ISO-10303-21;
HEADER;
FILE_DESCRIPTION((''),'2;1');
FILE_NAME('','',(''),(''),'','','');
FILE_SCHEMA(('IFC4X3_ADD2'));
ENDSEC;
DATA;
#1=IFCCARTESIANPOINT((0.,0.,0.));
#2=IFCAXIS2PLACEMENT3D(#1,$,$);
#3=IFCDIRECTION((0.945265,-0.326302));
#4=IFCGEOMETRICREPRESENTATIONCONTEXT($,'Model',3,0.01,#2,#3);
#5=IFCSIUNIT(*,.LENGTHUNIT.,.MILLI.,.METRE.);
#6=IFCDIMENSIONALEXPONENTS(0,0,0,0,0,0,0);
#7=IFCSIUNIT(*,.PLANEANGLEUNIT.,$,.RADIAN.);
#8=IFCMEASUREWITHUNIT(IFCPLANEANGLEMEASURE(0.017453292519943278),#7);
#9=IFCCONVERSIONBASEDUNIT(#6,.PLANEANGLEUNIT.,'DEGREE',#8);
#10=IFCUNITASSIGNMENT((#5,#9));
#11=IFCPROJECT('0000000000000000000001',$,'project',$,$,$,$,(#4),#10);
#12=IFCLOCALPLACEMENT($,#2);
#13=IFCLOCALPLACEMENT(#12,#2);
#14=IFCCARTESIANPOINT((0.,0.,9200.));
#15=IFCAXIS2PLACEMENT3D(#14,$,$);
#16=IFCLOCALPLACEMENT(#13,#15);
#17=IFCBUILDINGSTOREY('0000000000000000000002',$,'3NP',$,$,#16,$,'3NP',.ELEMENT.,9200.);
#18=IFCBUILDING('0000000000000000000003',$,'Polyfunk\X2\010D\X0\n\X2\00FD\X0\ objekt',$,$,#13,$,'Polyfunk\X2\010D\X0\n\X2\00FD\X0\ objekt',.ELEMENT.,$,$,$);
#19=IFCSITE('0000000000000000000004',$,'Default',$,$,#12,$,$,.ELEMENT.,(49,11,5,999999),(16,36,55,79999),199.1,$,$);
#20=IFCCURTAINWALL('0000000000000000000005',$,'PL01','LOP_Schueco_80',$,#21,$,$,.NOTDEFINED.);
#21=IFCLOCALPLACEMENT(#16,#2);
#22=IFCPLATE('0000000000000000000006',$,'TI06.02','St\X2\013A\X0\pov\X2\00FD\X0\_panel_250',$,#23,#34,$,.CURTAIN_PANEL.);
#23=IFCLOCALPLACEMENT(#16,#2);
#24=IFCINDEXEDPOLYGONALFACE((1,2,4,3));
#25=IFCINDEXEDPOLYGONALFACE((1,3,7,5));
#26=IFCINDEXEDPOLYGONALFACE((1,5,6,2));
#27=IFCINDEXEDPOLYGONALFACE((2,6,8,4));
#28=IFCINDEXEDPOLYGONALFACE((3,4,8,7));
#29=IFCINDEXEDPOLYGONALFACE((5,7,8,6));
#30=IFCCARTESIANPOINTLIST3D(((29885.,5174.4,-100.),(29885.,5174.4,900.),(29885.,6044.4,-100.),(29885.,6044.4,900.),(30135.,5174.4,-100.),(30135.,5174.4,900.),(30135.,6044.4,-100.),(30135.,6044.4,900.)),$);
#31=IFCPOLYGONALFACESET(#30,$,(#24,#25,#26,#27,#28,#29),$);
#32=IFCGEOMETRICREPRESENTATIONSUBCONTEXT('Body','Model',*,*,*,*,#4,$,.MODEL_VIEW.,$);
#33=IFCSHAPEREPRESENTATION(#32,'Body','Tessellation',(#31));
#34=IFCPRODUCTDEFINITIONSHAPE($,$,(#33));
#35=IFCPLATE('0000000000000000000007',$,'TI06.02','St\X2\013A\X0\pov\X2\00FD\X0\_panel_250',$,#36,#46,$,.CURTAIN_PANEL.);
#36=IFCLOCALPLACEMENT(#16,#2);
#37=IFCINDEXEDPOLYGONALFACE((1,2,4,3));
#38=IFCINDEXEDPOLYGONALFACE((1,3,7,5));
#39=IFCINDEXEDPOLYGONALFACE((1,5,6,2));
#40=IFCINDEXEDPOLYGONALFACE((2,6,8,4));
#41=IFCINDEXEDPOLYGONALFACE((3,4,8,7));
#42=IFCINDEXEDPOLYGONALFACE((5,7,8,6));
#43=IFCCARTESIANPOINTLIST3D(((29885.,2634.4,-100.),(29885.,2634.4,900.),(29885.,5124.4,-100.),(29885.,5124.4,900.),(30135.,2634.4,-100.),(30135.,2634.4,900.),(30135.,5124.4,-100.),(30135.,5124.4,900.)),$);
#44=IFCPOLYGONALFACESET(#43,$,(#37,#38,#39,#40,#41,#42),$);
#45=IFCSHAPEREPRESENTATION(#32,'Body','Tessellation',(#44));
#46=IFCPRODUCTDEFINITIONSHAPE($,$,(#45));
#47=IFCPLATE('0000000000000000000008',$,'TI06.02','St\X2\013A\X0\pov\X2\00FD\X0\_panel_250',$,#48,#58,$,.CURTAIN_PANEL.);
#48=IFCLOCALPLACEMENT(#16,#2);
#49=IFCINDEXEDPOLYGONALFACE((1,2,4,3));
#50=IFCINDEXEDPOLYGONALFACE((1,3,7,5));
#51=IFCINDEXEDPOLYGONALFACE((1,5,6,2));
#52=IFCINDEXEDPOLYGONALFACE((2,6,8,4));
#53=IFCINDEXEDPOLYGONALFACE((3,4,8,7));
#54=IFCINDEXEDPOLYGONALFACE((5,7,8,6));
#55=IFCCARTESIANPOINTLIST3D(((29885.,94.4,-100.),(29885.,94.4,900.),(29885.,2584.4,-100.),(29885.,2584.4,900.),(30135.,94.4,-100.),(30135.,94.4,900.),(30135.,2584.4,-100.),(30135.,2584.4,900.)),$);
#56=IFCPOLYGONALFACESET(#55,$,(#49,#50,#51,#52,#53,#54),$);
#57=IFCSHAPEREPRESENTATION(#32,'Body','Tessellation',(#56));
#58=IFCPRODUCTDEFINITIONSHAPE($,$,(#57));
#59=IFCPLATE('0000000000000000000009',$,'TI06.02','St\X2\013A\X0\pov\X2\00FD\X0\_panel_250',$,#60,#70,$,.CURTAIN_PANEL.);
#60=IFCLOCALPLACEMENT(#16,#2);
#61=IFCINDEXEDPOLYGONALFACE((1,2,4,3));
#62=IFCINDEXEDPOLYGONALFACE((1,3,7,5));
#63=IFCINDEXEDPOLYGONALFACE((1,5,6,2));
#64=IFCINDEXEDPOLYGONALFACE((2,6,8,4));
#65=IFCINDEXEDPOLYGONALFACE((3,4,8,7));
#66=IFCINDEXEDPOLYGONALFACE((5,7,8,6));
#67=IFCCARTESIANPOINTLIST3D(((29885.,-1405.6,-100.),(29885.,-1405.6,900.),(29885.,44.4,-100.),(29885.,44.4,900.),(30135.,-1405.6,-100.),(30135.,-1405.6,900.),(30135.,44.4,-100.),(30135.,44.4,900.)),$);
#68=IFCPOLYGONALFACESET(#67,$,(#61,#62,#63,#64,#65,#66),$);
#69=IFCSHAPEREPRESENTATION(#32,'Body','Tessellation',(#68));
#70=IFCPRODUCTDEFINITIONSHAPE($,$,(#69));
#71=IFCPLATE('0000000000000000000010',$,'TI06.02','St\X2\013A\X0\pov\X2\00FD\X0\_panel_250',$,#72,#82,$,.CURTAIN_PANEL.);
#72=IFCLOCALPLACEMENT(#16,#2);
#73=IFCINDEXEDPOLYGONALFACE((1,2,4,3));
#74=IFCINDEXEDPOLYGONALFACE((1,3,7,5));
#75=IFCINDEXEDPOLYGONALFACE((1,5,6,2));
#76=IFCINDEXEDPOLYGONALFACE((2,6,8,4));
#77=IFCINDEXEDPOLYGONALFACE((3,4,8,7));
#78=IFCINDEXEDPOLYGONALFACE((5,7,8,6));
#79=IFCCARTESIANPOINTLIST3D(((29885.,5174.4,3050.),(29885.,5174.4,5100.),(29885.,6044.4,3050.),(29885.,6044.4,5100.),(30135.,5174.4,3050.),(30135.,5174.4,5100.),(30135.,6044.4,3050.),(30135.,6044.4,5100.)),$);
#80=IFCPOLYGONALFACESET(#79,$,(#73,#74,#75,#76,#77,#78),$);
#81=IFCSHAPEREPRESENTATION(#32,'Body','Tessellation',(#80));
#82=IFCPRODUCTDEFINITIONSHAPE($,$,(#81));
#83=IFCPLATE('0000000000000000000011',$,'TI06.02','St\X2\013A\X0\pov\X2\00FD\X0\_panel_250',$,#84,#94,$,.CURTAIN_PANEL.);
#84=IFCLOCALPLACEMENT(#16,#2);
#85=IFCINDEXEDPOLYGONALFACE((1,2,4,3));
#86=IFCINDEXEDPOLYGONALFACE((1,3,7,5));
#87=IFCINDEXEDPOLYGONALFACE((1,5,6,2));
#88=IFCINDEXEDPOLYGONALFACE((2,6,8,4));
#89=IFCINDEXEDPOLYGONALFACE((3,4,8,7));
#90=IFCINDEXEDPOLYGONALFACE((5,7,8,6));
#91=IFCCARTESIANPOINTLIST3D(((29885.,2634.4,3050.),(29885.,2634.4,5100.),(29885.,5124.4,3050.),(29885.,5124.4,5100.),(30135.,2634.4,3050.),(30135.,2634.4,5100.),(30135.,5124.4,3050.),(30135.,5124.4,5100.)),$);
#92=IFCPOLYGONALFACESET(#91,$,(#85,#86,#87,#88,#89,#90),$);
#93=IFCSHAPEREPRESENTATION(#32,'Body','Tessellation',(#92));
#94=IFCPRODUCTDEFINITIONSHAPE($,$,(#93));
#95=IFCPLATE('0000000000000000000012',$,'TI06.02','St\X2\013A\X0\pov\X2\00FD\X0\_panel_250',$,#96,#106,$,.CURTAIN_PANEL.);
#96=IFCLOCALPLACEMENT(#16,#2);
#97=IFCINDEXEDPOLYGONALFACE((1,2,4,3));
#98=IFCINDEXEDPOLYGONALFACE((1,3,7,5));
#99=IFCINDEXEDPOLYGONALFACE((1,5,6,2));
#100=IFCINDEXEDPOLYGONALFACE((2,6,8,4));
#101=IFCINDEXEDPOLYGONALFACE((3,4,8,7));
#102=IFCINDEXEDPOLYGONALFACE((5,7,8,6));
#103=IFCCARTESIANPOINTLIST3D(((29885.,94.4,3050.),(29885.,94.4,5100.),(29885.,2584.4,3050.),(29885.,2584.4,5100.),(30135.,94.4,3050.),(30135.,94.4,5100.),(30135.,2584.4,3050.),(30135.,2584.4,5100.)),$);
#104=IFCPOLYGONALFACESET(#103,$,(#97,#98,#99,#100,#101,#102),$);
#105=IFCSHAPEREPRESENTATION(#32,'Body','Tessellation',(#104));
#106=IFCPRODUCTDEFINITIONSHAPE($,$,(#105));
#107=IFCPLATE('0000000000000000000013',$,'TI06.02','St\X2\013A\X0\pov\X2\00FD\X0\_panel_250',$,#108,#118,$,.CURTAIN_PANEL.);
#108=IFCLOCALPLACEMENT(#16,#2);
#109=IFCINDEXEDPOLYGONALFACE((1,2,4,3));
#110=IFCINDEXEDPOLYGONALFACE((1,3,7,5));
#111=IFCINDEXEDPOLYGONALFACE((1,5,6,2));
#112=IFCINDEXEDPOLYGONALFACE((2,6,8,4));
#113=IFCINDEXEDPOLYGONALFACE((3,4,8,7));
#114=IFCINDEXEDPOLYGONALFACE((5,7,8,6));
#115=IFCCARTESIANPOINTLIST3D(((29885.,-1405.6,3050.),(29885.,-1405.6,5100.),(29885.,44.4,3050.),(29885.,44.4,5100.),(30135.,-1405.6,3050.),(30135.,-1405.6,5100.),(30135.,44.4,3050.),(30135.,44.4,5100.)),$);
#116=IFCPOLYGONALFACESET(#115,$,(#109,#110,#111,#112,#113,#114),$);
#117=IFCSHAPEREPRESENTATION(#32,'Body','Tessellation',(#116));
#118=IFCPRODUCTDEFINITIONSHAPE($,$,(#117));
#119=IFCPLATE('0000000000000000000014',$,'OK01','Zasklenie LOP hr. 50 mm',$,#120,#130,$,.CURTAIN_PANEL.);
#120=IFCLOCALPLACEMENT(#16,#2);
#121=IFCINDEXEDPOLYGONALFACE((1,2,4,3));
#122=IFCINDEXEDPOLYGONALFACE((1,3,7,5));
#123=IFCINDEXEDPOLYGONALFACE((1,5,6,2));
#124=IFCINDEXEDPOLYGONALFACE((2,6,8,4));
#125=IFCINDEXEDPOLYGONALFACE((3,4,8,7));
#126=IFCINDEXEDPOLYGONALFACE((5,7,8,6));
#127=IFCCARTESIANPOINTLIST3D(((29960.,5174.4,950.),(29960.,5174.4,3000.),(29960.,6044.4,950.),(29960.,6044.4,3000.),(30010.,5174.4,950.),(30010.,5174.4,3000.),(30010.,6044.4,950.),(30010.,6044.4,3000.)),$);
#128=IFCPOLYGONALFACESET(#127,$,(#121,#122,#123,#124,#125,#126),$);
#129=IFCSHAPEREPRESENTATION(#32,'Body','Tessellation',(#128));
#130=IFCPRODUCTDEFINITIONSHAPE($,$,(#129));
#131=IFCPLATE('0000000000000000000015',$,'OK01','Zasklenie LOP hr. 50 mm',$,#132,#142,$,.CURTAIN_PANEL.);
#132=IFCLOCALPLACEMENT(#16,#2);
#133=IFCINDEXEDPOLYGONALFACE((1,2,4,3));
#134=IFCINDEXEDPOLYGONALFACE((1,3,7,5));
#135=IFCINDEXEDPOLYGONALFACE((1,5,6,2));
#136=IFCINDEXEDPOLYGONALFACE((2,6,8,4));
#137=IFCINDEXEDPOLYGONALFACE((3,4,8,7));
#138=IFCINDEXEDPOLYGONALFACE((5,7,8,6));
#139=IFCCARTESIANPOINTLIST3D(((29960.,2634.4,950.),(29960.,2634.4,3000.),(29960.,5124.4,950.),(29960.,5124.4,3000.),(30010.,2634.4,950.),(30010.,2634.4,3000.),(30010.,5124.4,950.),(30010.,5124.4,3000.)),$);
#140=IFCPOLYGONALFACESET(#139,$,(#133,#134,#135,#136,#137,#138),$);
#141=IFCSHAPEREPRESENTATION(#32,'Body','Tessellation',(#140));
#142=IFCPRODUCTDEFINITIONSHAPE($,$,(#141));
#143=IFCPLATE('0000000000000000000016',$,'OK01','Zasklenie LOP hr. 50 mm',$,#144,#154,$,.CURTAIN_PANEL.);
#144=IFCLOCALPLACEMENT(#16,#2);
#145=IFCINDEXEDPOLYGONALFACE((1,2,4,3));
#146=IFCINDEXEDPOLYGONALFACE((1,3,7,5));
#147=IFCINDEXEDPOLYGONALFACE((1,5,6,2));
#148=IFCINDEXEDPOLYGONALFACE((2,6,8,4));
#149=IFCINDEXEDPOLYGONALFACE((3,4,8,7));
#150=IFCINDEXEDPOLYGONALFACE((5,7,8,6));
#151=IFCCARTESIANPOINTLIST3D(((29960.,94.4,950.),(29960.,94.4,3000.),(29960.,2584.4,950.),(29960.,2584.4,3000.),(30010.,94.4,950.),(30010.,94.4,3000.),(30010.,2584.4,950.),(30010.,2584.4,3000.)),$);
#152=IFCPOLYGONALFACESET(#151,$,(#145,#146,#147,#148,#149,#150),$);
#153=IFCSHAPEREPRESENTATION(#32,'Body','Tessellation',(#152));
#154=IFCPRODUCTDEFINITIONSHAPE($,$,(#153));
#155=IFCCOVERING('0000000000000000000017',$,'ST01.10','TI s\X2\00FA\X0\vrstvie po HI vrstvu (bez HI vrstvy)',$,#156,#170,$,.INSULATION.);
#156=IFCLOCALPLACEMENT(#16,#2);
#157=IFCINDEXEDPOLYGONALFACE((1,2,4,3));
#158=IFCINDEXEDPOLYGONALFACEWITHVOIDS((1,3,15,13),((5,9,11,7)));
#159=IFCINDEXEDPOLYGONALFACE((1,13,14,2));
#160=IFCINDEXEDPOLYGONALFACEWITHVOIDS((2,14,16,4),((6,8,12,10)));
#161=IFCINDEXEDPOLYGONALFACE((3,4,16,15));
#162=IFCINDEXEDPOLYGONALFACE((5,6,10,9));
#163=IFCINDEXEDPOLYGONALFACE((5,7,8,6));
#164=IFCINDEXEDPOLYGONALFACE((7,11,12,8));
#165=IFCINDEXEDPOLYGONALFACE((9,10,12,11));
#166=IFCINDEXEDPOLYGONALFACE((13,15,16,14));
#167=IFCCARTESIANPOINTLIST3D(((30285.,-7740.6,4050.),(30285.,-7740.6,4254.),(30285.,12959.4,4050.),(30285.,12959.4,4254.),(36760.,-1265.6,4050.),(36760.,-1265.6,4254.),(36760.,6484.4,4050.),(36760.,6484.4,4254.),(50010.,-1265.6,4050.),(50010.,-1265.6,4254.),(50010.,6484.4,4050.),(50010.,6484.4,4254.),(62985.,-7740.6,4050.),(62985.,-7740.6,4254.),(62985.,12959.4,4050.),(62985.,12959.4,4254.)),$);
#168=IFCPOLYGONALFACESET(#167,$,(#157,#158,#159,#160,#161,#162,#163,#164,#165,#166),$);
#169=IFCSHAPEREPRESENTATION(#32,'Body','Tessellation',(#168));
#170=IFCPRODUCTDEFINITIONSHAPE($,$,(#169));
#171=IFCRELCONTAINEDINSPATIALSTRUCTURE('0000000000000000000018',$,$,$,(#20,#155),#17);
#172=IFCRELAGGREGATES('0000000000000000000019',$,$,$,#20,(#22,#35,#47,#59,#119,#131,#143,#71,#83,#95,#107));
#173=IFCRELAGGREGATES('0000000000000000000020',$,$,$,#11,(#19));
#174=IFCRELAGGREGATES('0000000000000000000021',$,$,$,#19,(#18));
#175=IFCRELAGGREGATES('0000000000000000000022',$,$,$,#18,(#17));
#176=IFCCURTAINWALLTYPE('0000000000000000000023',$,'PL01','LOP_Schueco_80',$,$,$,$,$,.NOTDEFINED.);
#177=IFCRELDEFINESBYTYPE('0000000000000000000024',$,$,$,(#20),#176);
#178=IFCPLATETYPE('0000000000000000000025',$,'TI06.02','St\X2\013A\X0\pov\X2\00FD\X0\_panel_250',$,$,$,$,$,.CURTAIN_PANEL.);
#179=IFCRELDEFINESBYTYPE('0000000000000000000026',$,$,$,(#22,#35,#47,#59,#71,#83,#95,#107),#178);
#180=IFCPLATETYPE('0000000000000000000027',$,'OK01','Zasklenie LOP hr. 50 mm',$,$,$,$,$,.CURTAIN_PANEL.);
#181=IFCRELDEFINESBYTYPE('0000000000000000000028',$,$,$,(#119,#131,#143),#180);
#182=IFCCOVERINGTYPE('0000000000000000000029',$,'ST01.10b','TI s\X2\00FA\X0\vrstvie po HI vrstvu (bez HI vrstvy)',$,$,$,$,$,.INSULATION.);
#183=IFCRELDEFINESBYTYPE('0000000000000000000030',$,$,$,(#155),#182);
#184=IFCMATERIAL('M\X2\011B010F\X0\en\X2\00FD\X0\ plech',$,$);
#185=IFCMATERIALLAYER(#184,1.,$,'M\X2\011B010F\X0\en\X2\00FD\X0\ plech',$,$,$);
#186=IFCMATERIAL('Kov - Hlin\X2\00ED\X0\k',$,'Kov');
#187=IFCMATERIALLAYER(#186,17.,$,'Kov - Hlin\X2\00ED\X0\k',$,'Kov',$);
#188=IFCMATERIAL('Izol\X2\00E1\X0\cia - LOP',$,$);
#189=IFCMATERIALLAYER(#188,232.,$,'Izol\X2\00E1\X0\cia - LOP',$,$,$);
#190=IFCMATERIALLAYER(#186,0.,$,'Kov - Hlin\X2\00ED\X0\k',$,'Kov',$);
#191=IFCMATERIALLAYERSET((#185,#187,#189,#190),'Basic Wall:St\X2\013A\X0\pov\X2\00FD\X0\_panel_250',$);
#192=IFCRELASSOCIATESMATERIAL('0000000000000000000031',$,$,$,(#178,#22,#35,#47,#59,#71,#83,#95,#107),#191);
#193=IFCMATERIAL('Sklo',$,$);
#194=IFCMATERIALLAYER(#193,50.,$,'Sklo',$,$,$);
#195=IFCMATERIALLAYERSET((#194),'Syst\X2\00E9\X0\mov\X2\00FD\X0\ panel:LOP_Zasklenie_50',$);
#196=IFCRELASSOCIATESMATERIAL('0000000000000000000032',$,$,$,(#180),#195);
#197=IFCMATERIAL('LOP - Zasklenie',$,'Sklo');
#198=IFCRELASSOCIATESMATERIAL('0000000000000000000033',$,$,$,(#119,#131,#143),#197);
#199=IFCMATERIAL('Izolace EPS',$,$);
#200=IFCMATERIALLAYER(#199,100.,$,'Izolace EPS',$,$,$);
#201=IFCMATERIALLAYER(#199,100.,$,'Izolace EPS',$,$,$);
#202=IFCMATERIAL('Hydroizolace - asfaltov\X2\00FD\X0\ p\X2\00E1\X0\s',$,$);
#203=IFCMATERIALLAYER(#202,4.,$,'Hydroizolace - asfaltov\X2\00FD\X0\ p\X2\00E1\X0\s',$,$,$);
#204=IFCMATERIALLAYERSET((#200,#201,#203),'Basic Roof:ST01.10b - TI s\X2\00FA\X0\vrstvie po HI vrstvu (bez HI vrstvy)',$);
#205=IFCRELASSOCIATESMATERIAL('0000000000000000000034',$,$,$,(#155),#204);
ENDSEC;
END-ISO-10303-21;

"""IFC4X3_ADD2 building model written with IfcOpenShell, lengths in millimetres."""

from ifc_helpers import new_model, entity, si_unit, converted_unit, direction, frame, frame_2d, origin, origin_2d_with_axis, place, context, subcontext, project, spatial, rectangle, extrude, source, transform, mapped, material, layer, layer_set, layer_usage, type_object, type_shapes, element, aggregate, save


model = new_model("IFC4X3_ADD2")

# Units and contexts
model_context = context("Model", 3, precision=0.01, world=origin(), true_north=direction((0.945265, -0.326302)))
body_context = subcontext(model_context, "Body", "Model", "MODEL_VIEW")
ifc_project = project(units=[si_unit("LENGTHUNIT", "METRE", prefix="MILLI"), converted_unit("PLANEANGLEUNIT", "DEGREE", entity("IfcPlaneAngleMeasure", 0.017453292519943278), si_unit("PLANEANGLEUNIT", "RADIAN"), dimensions=[0, 0, 0, 0, 0, 0, 0])], contexts=[model_context])

# Site, building, storey
site_placement = place(None, origin())
site = spatial("IfcSite", under=ifc_project, at=site_placement, Name="Default", CompositionType="ELEMENT", RefLatitude=(49, 11, 5, 999999), RefLongitude=(16, 36, 55, 79999), RefElevation=199.1)
building_placement = place(site_placement, origin())
building = spatial("IfcBuilding", under=site, at=building_placement, Name="Polyfunkčný objekt", LongName="Polyfunkčný objekt", CompositionType="ELEMENT")
storey_placement = place(building_placement, frame((0.0, 0.0, 9200.0)))
storey = spatial("IfcBuildingStorey", under=building, at=storey_placement, Name="3NP", LongName="3NP", CompositionType="ELEMENT", Elevation=9200.0)

# Curtain wall
curtain_wall_type = type_object("IfcCurtainWallType", Name="PL01", Description="LOP_Schueco_80", PredefinedType="NOTDEFINED")
curtain_wall_1_placement = place(storey_placement, frame((0.0, 0.0, -9200.0)))
curtain_wall_1 = element("IfcCurtainWall", 1, at=curtain_wall_1_placement, inside=storey, type_object=curtain_wall_type, Name="PL01", Description="LOP_Schueco_80", PredefinedType="NOTDEFINED")

# Plates
ifc_material_1 = material(Name="Měďený plech")
ifc_layer_1 = layer(ifc_material_1, 1.0, Name="Měďený plech")
ifc_material_2 = material(Name="Kov - Hliník", Category="Kov")
ifc_layer_2 = layer(ifc_material_2, 17.0, Name="Kov - Hliník", Category="Kov")
ifc_material_3 = material(Name="Izolácia - LOP")
ifc_layer_3 = layer(ifc_material_3, 232.0, Name="Izolácia - LOP")
ifc_layer_4 = layer(ifc_material_2, 0.0, Name="Kov - Hliník", Category="Kov")
ifc_layer_set_1 = layer_set([ifc_layer_1, ifc_layer_2, ifc_layer_3, ifc_layer_4], Name="Basic Wall:Stĺpový_panel_250")
ifc_layer_usage_1 = layer_usage(ifc_layer_set_1, "AXIS2", "POSITIVE", -125.0)
plate_type_1 = type_object("IfcPlateType", Name="TI06.02", Description="Stĺpový_panel_250", PredefinedType="CURTAIN_PANEL", material=ifc_layer_set_1)
plate_1_placement = place(storey_placement, frame((30010.0, 6044.4, -100.0), z_axis=(0.0, 0.0, 1.0), x_axis=(0.0, -1.0, 0.0)))
plate_1 = element("IfcPlate", 2, at=plate_1_placement, type_object=plate_type_1, material=ifc_layer_usage_1, Name="TI06.02", Description="Stĺpový_panel_250", PredefinedType="CURTAIN_PANEL", context=body_context, shape_type="SweptSolid", body=[
    extrude(rectangle(XDim=250.0, YDim=870.0, at=frame_2d((0.0, 0.0), x_axis=(1.0, 0.0))), frame((435.0, 0.0, 0.0), z_axis=(0.0, 0.0, 1.0), x_axis=(0.0, 1.0, 0.0)), (0.0, 0.0, 1.0), 1000.0),
])
ifc_layer_usage_2 = layer_usage(ifc_layer_set_1, "AXIS2", "POSITIVE", -125.0)
plate_2_placement = place(storey_placement, frame((30010.0, 5124.4, -100.0), z_axis=(0.0, 0.0, 1.0), x_axis=(0.0, -1.0, 0.0)))
plate_2 = element("IfcPlate", 3, at=plate_2_placement, type_object=plate_type_1, material=ifc_layer_usage_2, Name="TI06.02", Description="Stĺpový_panel_250", PredefinedType="CURTAIN_PANEL", context=body_context, shape_type="SweptSolid", body=[
    extrude(rectangle(XDim=250.0, YDim=2490.0, at=frame_2d((0.0, 0.0), x_axis=(1.0, 0.0))), frame((1245.0, 0.0, 0.0), z_axis=(0.0, 0.0, 1.0), x_axis=(0.0, 1.0, 0.0)), (0.0, 0.0, 1.0), 1000.0),
])
ifc_layer_usage_3 = layer_usage(ifc_layer_set_1, "AXIS2", "POSITIVE", -125.0)
plate_3_placement = place(storey_placement, frame((30010.0, 2584.4, -100.0), z_axis=(0.0, 0.0, 1.0), x_axis=(0.0, -1.0, 0.0)))
plate_3 = element("IfcPlate", 4, at=plate_3_placement, type_object=plate_type_1, material=ifc_layer_usage_3, Name="TI06.02", Description="Stĺpový_panel_250", PredefinedType="CURTAIN_PANEL", context=body_context, shape_type="SweptSolid", body=[
    extrude(rectangle(XDim=250.0, YDim=2490.0, at=frame_2d((0.0, 0.0), x_axis=(1.0, 0.0))), frame((1245.0, 0.0, 0.0), z_axis=(0.0, 0.0, 1.0), x_axis=(0.0, 1.0, 0.0)), (0.0, 0.0, 1.0), 1000.0),
])
ifc_layer_usage_4 = layer_usage(ifc_layer_set_1, "AXIS2", "POSITIVE", -125.0)
plate_4_placement = place(storey_placement, frame((30010.0, 44.4, -100.0), z_axis=(0.0, 0.0, 1.0), x_axis=(0.0, -1.0, 0.0)))
plate_4 = element("IfcPlate", 5, at=plate_4_placement, type_object=plate_type_1, material=ifc_layer_usage_4, Name="TI06.02", Description="Stĺpový_panel_250", PredefinedType="CURTAIN_PANEL", context=body_context, shape_type="SweptSolid", body=[
    extrude(rectangle(XDim=250.0, YDim=1450.0, at=frame_2d((0.0, 0.0), x_axis=(1.0, 0.0))), frame((725.0, 0.0, 0.0), z_axis=(0.0, 0.0, 1.0), x_axis=(0.0, 1.0, 0.0)), (0.0, 0.0, 1.0), 1000.0),
])
ifc_layer_usage_5 = layer_usage(ifc_layer_set_1, "AXIS2", "POSITIVE", -125.0)
plate_5_placement = place(storey_placement, frame((30010.0, 6044.4, 3050.0), z_axis=(0.0, 0.0, 1.0), x_axis=(0.0, -1.0, 0.0)))
plate_5 = element("IfcPlate", 6, at=plate_5_placement, type_object=plate_type_1, material=ifc_layer_usage_5, Name="TI06.02", Description="Stĺpový_panel_250", PredefinedType="CURTAIN_PANEL", context=body_context, shape_type="SweptSolid", body=[
    extrude(rectangle(XDim=250.0, YDim=870.0, at=frame_2d((0.0, 0.0), x_axis=(1.0, 0.0))), frame((435.0, 0.0, 0.0), z_axis=(0.0, 0.0, 1.0), x_axis=(0.0, 1.0, 0.0)), (0.0, 0.0, 1.0), 2050.0),
])
ifc_layer_usage_6 = layer_usage(ifc_layer_set_1, "AXIS2", "POSITIVE", -125.0)
plate_6_placement = place(storey_placement, frame((30010.0, 5124.4, 3050.0), z_axis=(0.0, 0.0, 1.0), x_axis=(0.0, -1.0, 0.0)))
plate_6 = element("IfcPlate", 7, at=plate_6_placement, type_object=plate_type_1, material=ifc_layer_usage_6, Name="TI06.02", Description="Stĺpový_panel_250", PredefinedType="CURTAIN_PANEL", context=body_context, shape_type="SweptSolid", body=[
    extrude(rectangle(XDim=250.0, YDim=2490.0, at=frame_2d((0.0, 0.0), x_axis=(1.0, 0.0))), frame((1245.0, 0.0, 0.0), z_axis=(0.0, 0.0, 1.0), x_axis=(0.0, 1.0, 0.0)), (0.0, 0.0, 1.0), 2050.0),
])
ifc_layer_usage_7 = layer_usage(ifc_layer_set_1, "AXIS2", "POSITIVE", -125.0)
plate_7_placement = place(storey_placement, frame((30010.0, 2584.4, 3050.0), z_axis=(0.0, 0.0, 1.0), x_axis=(0.0, -1.0, 0.0)))
plate_7 = element("IfcPlate", 8, at=plate_7_placement, type_object=plate_type_1, material=ifc_layer_usage_7, Name="TI06.02", Description="Stĺpový_panel_250", PredefinedType="CURTAIN_PANEL", context=body_context, shape_type="SweptSolid", body=[
    extrude(rectangle(XDim=250.0, YDim=2490.0, at=frame_2d((0.0, 0.0), x_axis=(1.0, 0.0))), frame((1245.0, 0.0, 0.0), z_axis=(0.0, 0.0, 1.0), x_axis=(0.0, 1.0, 0.0)), (0.0, 0.0, 1.0), 2050.0),
])
ifc_layer_usage_8 = layer_usage(ifc_layer_set_1, "AXIS2", "POSITIVE", -125.0)
plate_8_placement = place(storey_placement, frame((30010.0, 44.4, 3050.0), z_axis=(0.0, 0.0, 1.0), x_axis=(0.0, -1.0, 0.0)))
plate_8 = element("IfcPlate", 9, at=plate_8_placement, type_object=plate_type_1, material=ifc_layer_usage_8, Name="TI06.02", Description="Stĺpový_panel_250", PredefinedType="CURTAIN_PANEL", context=body_context, shape_type="SweptSolid", body=[
    extrude(rectangle(XDim=250.0, YDim=1450.0, at=frame_2d((0.0, 0.0), x_axis=(1.0, 0.0))), frame((725.0, 0.0, 0.0), z_axis=(0.0, 0.0, 1.0), x_axis=(0.0, 1.0, 0.0)), (0.0, 0.0, 1.0), 2050.0),
])
ifc_material_4 = material(Name="LOP - Zasklenie", Category="Sklo")
ifc_material_5 = material(Name="Sklo")
ifc_layer_5 = layer(ifc_material_5, 50.0, Name="Sklo")
ifc_layer_set_2 = layer_set([ifc_layer_5], Name="Systémový panel:LOP_Zasklenie_50")
plate_type_2 = type_object("IfcPlateType", Name="OK01", Description="Zasklenie LOP hr. 50 mm", PredefinedType="CURTAIN_PANEL", material=ifc_layer_set_2)
shared_shape_1 = source(origin(), body_context, "Body", "SweptSolid", [
    extrude(rectangle(XDim=50.0, YDim=870.0, at=origin_2d_with_axis()), frame((0.0, -25.0, 0.0), z_axis=(0.0, 0.0, 1.0), x_axis=(0.0, 1.0, 0.0)), (0.0, 0.0, 1.0), 2050.0),
])
plate_9_placement = place(curtain_wall_1_placement, frame((30010.0, 5609.4, 10150.0), z_axis=(0.0, 0.0, 1.0), x_axis=(0.0, -1.0, 0.0)))
plate_9 = element("IfcPlate", 10, at=plate_9_placement, type_object=plate_type_2, material=ifc_material_4, Name="OK01", Description="Zasklenie LOP hr. 50 mm", PredefinedType="CURTAIN_PANEL", context=body_context, shape_type="MappedRepresentation", body=[
    mapped(shared_shape_1, transform((0.0, 0.0, 0.0), scale=1.0)),
])
shared_shape_2 = source(origin(), body_context, "Body", "SweptSolid", [
    extrude(rectangle(XDim=50.0, YDim=2490.0, at=origin_2d_with_axis()), frame((0.0, -25.0, 0.0), z_axis=(0.0, 0.0, 1.0), x_axis=(0.0, 1.0, 0.0)), (0.0, 0.0, 1.0), 2050.0),
])
type_shapes(plate_type_2, [shared_shape_1, shared_shape_2])
plate_10_placement = place(curtain_wall_1_placement, frame((30010.0, 3879.4, 10150.0), z_axis=(0.0, 0.0, 1.0), x_axis=(0.0, -1.0, 0.0)))
plate_10 = element("IfcPlate", 11, at=plate_10_placement, type_object=plate_type_2, material=ifc_material_4, Name="OK01", Description="Zasklenie LOP hr. 50 mm", PredefinedType="CURTAIN_PANEL", context=body_context, shape_type="MappedRepresentation", body=[
    mapped(shared_shape_2, transform((0.0, 0.0, 0.0), scale=1.0)),
])
plate_11_placement = place(curtain_wall_1_placement, frame((30010.0, 1339.4, 10150.0), z_axis=(0.0, 0.0, 1.0), x_axis=(0.0, -1.0, 0.0)))
plate_11 = element("IfcPlate", 12, at=plate_11_placement, type_object=plate_type_2, material=ifc_material_4, Name="OK01", Description="Zasklenie LOP hr. 50 mm", PredefinedType="CURTAIN_PANEL", context=body_context, shape_type="MappedRepresentation", body=[
    mapped(shared_shape_2, transform((0.0, 0.0, 0.0), scale=1.0)),
])
aggregate(curtain_wall_1, [plate_1, plate_2, plate_3, plate_4, plate_9, plate_10, plate_11, plate_5, plate_6, plate_7, plate_8])

# Covering, opening
ifc_material_6 = material(Name="Izolace EPS")
ifc_layer_6 = layer(ifc_material_6, 100.0, Name="Izolace EPS")
ifc_layer_7 = layer(ifc_material_6, 100.0, Name="Izolace EPS")
ifc_material_7 = material(Name="Hydroizolace - asfaltový pás")
ifc_layer_8 = layer(ifc_material_7, 4.0, Name="Hydroizolace - asfaltový pás")
ifc_layer_set_3 = layer_set([ifc_layer_6, ifc_layer_7, ifc_layer_8], Name="Basic Roof:ST01.10b - TI súvrstvie po HI vrstvu (bez HI vrstvy)")
covering_type_1 = type_object("IfcCoveringType", Name="ST01.10b", Description="TI súvrstvie po HI vrstvu (bez HI vrstvy)", PredefinedType="INSULATION")
covering_1_placement = place(storey_placement, frame((30285.0, -7740.6, 4050.0)))
covering_1 = element("IfcCovering", 13, at=covering_1_placement, inside=storey, type_object=covering_type_1, material=ifc_layer_set_3, Name="ST01.10", Description="TI súvrstvie po HI vrstvu (bez HI vrstvy)", PredefinedType="INSULATION", context=body_context, shape_type="SweptSolid", body=[
    extrude(rectangle(XDim=20700.0, YDim=32700.0, at=frame_2d((0.0, 0.0), x_axis=(1.0, 0.0))), frame((16350.0, 10350.0, 0.0), z_axis=(0.0, 0.0, 1.0), x_axis=(0.0, -1.0, 0.0)), (0.0, 0.0, 1.0), 204.0),
])
opening_placement = place(storey_placement, frame((30285.0, -7740.6, 4050.0)))
element("IfcOpeningElement", 14, at=opening_placement, cuts=covering_1, PredefinedType="OPENING", context=body_context, shape_type="SweptSolid", body=[
    extrude(rectangle(XDim=7750.0, YDim=13250.0, at=frame_2d((-31.2, 31.2), x_axis=(1.0, 0.0))), frame((13131.3, 10381.2, 0.0), z_axis=(0.0, 0.0, 1.0), x_axis=(0.0, 1.0, 0.0)), (0.0, 0.0, 1.0), 204.0),
])

save(model, "model.ifc")
